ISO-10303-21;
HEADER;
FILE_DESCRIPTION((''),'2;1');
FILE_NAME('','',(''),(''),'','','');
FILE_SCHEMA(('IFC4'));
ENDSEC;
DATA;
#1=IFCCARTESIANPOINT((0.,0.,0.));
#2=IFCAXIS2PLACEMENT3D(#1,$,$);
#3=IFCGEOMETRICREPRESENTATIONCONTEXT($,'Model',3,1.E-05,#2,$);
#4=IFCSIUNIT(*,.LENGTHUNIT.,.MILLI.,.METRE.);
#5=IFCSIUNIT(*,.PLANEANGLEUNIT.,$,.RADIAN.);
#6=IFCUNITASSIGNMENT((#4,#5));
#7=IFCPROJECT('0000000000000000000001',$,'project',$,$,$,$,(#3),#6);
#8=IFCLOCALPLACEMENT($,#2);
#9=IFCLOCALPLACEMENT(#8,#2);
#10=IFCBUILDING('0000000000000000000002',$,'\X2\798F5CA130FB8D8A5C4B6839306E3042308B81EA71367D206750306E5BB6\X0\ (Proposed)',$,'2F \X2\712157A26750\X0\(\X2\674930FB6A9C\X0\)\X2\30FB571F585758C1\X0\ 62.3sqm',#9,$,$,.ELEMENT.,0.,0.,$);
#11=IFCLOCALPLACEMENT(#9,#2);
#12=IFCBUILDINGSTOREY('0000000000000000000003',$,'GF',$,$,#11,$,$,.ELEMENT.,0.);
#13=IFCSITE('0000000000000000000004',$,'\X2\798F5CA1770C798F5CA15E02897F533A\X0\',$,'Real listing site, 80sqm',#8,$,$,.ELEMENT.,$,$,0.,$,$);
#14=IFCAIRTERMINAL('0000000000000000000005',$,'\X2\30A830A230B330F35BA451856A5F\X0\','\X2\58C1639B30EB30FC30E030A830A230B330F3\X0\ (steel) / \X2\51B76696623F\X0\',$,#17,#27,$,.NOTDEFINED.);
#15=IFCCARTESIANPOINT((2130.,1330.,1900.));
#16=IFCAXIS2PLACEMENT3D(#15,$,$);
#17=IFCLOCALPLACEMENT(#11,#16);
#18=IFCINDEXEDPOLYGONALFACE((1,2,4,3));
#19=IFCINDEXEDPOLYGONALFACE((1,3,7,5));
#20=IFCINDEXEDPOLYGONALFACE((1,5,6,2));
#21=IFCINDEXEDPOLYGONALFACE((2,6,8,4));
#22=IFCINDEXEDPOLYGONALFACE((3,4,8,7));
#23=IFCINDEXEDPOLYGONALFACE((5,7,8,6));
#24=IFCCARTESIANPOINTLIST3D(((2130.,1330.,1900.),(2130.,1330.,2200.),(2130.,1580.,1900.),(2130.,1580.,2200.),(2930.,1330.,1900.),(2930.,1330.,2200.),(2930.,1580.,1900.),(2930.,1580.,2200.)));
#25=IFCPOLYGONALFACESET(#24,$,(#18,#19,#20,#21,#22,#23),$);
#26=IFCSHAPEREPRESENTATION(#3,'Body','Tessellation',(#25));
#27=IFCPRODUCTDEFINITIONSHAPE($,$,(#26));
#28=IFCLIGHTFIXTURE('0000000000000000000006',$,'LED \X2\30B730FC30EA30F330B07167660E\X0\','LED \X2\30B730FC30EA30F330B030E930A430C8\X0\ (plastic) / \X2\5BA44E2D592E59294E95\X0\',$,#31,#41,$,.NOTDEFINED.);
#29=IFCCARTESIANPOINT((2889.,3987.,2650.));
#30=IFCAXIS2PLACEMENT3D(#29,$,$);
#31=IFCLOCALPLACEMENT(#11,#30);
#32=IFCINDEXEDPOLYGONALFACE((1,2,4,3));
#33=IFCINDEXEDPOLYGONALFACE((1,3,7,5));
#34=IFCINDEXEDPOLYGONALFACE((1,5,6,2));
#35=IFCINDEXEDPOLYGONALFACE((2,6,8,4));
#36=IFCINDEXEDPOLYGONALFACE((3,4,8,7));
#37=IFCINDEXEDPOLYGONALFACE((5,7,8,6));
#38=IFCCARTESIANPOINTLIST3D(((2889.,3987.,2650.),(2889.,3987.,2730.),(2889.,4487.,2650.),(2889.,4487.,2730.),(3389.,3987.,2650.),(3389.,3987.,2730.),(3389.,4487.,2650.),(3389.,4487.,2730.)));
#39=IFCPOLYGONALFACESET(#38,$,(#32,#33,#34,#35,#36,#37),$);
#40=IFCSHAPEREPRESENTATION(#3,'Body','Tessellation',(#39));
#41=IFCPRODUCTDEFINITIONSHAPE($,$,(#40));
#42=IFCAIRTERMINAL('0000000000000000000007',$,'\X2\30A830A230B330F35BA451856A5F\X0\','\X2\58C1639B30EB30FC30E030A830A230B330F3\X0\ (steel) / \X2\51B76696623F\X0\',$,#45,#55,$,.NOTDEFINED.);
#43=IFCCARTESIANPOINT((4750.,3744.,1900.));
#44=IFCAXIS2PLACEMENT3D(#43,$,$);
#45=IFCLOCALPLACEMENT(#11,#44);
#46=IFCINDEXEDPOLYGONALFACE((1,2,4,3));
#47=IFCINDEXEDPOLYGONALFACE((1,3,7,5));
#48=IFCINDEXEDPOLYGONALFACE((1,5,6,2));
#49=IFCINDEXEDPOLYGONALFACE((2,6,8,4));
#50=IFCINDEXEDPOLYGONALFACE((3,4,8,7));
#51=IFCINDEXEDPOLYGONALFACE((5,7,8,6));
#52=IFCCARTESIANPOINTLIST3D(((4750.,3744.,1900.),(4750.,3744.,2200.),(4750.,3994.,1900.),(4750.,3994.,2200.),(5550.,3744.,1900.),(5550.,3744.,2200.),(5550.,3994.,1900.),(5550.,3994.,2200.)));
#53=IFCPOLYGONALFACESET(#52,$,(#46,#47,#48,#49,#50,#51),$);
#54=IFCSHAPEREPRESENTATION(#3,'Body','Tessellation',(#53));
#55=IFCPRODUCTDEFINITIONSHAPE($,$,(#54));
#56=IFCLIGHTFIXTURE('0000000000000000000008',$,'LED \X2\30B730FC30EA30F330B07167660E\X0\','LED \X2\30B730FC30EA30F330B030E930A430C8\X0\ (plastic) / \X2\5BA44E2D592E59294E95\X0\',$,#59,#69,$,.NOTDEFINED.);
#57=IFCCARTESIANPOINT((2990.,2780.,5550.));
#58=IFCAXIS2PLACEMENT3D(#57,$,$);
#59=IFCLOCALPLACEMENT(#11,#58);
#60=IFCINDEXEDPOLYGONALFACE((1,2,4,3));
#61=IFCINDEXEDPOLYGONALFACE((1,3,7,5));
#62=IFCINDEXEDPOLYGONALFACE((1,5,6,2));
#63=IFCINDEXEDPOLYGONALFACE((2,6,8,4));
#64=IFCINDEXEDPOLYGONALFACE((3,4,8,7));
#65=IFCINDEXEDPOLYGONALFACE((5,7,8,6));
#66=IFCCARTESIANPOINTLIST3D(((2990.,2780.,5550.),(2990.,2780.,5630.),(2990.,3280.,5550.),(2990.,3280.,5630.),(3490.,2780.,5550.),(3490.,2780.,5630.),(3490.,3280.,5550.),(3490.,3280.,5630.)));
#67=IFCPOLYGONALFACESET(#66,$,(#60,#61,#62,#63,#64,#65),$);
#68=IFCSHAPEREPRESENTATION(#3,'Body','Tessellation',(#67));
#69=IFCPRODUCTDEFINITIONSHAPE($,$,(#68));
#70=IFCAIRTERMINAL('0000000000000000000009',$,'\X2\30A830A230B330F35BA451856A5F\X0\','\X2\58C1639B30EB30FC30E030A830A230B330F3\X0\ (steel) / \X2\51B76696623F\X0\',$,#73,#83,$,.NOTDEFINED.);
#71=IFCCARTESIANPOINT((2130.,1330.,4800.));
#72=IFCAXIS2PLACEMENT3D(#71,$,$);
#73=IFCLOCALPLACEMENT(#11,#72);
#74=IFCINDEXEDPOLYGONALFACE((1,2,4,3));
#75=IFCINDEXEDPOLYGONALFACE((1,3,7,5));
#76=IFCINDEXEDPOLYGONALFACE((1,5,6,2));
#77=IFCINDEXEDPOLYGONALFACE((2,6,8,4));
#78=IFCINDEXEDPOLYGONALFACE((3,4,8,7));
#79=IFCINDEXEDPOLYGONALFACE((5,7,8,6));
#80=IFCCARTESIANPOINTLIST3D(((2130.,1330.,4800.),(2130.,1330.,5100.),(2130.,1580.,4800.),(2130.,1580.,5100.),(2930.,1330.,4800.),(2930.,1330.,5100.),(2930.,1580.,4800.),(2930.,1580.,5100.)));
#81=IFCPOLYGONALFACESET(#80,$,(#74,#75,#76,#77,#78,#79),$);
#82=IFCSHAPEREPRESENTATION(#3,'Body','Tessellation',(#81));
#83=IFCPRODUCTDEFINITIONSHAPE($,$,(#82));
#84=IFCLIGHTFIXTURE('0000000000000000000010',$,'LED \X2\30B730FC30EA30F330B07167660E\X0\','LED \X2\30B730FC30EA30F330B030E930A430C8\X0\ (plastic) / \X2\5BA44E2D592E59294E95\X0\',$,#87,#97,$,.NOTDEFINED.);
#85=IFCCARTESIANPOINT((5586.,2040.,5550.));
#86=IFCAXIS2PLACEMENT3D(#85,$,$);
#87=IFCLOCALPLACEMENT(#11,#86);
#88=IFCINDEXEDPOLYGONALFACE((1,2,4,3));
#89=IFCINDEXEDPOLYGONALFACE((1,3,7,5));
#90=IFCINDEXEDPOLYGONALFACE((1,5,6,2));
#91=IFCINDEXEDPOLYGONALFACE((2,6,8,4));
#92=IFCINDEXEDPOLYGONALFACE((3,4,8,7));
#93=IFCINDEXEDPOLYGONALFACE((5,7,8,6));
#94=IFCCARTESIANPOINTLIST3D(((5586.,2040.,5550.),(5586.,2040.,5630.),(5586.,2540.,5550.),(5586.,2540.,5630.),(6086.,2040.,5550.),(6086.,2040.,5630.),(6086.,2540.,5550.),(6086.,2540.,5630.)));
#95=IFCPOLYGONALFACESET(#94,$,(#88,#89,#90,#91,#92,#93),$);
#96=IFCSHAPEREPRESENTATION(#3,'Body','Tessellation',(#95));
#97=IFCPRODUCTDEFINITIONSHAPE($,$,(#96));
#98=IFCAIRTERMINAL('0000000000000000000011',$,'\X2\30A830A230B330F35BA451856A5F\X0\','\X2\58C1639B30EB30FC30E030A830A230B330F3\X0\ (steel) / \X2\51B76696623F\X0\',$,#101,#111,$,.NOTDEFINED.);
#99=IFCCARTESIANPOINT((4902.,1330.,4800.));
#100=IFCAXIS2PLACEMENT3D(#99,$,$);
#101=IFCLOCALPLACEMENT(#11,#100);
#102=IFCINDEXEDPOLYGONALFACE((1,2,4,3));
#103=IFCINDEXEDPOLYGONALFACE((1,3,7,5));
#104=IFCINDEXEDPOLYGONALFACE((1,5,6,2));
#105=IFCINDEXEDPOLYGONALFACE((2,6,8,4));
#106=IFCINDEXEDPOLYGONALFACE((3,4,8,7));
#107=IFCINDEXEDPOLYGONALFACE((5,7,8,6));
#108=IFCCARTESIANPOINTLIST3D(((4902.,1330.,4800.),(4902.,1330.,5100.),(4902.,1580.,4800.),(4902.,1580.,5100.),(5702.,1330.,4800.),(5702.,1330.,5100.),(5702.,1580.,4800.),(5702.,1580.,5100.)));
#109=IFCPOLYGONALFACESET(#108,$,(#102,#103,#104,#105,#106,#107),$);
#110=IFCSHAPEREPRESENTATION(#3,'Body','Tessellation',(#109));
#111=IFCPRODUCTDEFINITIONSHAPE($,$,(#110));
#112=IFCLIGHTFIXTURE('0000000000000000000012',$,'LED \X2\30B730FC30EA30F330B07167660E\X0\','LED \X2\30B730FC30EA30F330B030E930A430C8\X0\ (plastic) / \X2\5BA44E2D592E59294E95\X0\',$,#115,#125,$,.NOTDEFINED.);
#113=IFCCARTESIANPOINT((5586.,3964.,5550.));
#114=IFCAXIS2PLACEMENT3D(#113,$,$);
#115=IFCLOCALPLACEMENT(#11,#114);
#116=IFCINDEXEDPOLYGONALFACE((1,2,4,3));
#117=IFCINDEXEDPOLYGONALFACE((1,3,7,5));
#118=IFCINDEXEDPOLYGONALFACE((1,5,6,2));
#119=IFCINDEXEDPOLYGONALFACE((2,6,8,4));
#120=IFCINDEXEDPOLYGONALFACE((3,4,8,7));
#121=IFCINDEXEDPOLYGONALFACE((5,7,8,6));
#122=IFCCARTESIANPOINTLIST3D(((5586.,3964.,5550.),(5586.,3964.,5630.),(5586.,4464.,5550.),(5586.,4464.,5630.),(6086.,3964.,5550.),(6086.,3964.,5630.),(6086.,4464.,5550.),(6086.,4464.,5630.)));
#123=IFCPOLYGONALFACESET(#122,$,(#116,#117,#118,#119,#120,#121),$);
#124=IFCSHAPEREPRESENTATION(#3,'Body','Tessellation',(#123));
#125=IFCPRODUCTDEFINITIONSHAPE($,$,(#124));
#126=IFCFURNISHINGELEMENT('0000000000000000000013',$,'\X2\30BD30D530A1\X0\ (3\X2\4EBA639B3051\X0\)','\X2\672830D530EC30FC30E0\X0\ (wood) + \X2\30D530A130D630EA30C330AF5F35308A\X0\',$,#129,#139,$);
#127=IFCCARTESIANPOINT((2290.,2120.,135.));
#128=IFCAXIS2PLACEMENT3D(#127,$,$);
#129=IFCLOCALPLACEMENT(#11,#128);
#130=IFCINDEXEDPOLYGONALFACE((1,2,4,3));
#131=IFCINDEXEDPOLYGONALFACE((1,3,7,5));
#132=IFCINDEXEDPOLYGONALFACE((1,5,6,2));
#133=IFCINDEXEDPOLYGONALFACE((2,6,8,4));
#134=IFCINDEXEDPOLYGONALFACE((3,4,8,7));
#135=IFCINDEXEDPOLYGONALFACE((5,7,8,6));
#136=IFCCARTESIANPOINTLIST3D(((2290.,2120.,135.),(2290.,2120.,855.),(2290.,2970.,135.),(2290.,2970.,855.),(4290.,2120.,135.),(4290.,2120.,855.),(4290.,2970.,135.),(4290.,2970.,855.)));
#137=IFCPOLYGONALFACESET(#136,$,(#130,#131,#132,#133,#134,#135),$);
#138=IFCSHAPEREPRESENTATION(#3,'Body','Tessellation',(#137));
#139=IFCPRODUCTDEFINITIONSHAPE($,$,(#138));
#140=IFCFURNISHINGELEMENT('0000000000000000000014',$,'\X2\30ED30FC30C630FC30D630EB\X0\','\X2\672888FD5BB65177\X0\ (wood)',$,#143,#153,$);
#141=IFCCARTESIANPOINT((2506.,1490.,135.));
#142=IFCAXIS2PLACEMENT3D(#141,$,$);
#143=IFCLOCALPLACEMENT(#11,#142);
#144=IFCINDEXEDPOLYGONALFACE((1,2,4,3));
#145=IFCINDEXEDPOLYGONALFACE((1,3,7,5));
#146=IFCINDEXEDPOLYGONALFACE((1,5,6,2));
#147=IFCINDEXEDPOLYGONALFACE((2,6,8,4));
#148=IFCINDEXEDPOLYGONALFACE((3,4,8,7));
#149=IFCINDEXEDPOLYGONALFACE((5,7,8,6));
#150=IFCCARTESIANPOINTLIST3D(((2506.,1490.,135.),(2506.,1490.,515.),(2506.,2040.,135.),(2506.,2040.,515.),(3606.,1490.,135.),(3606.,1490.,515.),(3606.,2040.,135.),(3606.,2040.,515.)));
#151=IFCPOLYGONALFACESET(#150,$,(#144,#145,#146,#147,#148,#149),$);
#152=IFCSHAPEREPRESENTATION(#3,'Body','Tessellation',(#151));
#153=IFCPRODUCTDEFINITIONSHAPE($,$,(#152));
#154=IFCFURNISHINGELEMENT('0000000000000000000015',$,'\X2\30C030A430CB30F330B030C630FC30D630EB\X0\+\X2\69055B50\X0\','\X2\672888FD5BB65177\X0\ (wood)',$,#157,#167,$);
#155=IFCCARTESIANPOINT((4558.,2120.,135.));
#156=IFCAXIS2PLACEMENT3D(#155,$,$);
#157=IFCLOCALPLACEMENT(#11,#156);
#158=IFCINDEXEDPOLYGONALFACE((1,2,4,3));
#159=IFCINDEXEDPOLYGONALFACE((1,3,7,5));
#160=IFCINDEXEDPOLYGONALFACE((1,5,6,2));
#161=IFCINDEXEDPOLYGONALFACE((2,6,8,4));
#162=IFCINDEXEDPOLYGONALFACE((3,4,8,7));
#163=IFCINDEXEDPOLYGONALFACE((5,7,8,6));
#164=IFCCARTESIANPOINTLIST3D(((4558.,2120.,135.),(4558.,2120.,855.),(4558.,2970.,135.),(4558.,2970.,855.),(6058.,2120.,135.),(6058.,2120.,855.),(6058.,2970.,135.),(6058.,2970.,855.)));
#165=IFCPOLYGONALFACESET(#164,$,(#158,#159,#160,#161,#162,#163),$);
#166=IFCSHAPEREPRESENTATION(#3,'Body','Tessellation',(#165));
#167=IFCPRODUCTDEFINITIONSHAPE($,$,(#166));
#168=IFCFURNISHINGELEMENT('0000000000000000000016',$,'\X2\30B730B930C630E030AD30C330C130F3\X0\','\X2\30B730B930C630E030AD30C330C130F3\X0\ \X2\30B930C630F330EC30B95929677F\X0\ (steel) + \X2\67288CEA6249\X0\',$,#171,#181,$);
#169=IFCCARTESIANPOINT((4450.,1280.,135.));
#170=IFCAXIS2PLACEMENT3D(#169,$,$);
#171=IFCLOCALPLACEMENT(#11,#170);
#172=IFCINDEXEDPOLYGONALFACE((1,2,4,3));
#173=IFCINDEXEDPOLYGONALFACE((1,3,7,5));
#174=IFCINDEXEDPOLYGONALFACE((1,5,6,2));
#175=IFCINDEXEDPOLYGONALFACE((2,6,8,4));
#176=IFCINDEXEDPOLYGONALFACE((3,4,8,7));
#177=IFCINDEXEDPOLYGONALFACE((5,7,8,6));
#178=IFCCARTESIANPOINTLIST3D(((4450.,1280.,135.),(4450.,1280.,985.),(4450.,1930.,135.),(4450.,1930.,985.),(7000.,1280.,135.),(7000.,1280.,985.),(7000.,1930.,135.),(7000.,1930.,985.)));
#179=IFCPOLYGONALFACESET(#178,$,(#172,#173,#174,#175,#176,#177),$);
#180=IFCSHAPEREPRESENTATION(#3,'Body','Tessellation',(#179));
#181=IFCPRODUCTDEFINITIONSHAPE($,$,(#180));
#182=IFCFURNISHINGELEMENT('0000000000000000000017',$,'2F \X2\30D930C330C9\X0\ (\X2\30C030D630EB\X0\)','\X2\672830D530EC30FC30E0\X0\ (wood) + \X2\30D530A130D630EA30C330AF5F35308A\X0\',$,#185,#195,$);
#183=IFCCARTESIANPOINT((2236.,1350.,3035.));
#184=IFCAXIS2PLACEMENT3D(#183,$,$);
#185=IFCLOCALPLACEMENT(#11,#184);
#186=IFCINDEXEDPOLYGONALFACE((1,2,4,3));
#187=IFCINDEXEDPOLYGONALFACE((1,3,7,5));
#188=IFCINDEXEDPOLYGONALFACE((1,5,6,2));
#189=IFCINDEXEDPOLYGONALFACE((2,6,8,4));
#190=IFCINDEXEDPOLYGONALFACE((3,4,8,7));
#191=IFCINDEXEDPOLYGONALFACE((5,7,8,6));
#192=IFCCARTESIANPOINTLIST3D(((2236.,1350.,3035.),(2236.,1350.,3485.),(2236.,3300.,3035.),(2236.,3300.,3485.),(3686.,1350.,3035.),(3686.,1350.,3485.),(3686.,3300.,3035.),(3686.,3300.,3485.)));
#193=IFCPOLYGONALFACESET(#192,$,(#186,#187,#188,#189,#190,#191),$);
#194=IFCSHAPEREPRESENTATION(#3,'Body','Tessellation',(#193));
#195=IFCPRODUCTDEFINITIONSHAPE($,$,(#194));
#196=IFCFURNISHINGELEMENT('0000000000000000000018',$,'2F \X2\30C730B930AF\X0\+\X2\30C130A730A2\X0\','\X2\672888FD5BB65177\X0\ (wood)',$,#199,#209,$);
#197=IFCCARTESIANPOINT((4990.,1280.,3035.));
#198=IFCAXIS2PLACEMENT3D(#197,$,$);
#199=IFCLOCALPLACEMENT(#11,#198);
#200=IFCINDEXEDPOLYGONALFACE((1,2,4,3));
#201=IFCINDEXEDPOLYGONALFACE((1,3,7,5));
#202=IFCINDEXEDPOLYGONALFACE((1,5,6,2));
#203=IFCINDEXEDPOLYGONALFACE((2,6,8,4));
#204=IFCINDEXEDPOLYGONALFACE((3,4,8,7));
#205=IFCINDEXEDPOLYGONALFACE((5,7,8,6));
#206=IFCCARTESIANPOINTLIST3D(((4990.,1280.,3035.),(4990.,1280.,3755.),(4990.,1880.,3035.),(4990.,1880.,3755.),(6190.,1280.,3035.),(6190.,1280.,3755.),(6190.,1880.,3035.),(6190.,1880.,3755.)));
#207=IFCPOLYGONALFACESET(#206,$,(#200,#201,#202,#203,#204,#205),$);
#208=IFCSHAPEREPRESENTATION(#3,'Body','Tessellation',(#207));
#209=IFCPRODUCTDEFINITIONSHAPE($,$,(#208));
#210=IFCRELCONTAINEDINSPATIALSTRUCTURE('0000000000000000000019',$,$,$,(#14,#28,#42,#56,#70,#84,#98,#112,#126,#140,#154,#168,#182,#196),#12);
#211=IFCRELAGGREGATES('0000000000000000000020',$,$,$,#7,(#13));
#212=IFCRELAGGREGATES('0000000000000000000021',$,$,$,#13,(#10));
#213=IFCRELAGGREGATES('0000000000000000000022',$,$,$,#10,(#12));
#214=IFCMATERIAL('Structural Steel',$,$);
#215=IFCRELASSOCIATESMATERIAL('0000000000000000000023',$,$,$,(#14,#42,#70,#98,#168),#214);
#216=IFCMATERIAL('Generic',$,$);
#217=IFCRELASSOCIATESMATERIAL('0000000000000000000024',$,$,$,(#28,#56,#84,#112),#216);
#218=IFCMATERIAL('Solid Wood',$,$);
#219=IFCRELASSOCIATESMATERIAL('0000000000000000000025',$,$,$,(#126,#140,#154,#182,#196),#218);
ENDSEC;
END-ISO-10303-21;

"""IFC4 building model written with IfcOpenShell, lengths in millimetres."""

from ifc_helpers import new_model, si_unit, frame, frame_2d, origin, place, context, project, spatial, rectangle, extrude, material, element, save


model = new_model("IFC4")

# Units and contexts
model_context = context("Model", 3, precision=1e-05, world=origin())
ifc_project = project(units=[si_unit("LENGTHUNIT", "METRE", prefix="MILLI"), si_unit("PLANEANGLEUNIT", "RADIAN")], contexts=[model_context])

# Site, building, storey
site_placement = place(None, origin())
site = spatial("IfcSite", under=ifc_project, at=site_placement, Name="福岡県福岡市西区", ObjectType="Real listing site, 80sqm", CompositionType="ELEMENT", RefElevation=0.0)
building_placement = place(site_placement, origin())
building = spatial("IfcBuilding", under=site, at=building_placement, Name="福岡・越屋根のある自然素材の家 (Proposed)", ObjectType="2F 無垢材(杉・檜)・土塗壁 62.3sqm", CompositionType="ELEMENT", ElevationOfRefHeight=0.0, ElevationOfTerrain=0.0)
storey_placement = place(building_placement, origin())
storey = spatial("IfcBuildingStorey", under=building, at=storey_placement, Name="GF", CompositionType="ELEMENT", Elevation=0.0)

# Shared definitions
ifc_material_1 = material(Name="Solid Wood")

# Shared definitions
ifc_material_2 = material(Name="Structural Steel")

# Shared definitions
ifc_material_3 = material(Name="Generic")

# Air terminal
air_terminal_1_placement = place(storey_placement, frame((2130.0, 1330.0, 1900.0)))
element("IfcAirTerminal", 1, at=air_terminal_1_placement, inside=storey, material=ifc_material_2, Name="エアコン室内機", Description="壁掛ルームエアコン (steel) / 冷暖房", PredefinedType="NOTDEFINED", context=model_context, shape_type="SweptSolid", body=[
    extrude(rectangle(XDim=800.0, YDim=250.0, at=frame_2d((400.0, 125.0))), frame((2130.0, 1330.0, 1900.0)), (0.0, 0.0, 1.0), 300.0),
])

# Light fixture
light_fixture_1_placement = place(storey_placement, frame((2889.0, 3987.0, 2650.0)))
element("IfcLightFixture", 2, at=light_fixture_1_placement, inside=storey, material=ifc_material_3, Name="LED シーリング照明", Description="LED シーリングライト (plastic) / 室中央天井", PredefinedType="NOTDEFINED", context=model_context, shape_type="SweptSolid", body=[
    extrude(rectangle(XDim=500.0, YDim=500.0, at=frame_2d((250.0, 250.0))), frame((2889.0, 3987.0, 2650.0)), (0.0, 0.0, 1.0), 80.0),
])

# Air terminal
air_terminal_2_placement = place(storey_placement, frame((4750.0, 3744.0, 1900.0)))
element("IfcAirTerminal", 3, at=air_terminal_2_placement, inside=storey, material=ifc_material_2, Name="エアコン室内機", Description="壁掛ルームエアコン (steel) / 冷暖房", PredefinedType="NOTDEFINED", context=model_context, shape_type="SweptSolid", body=[
    extrude(rectangle(XDim=800.0, YDim=250.0, at=frame_2d((400.0, 125.0))), frame((4750.0, 3744.0, 1900.0)), (0.0, 0.0, 1.0), 300.0),
])

# Light fixture
light_fixture_2_placement = place(storey_placement, frame((2990.0, 2780.0, 5550.0)))
element("IfcLightFixture", 4, at=light_fixture_2_placement, inside=storey, material=ifc_material_3, Name="LED シーリング照明", Description="LED シーリングライト (plastic) / 室中央天井", PredefinedType="NOTDEFINED", context=model_context, shape_type="SweptSolid", body=[
    extrude(rectangle(XDim=500.0, YDim=500.0, at=frame_2d((250.0, 250.0))), frame((2990.0, 2780.0, 5550.0)), (0.0, 0.0, 1.0), 80.0),
])

# Air terminal
air_terminal_3_placement = place(storey_placement, frame((2130.0, 1330.0, 4800.0)))
element("IfcAirTerminal", 5, at=air_terminal_3_placement, inside=storey, material=ifc_material_2, Name="エアコン室内機", Description="壁掛ルームエアコン (steel) / 冷暖房", PredefinedType="NOTDEFINED", context=model_context, shape_type="SweptSolid", body=[
    extrude(rectangle(XDim=800.0, YDim=250.0, at=frame_2d((400.0, 125.0))), frame((2130.0, 1330.0, 4800.0)), (0.0, 0.0, 1.0), 300.0),
])

# Light fixture
light_fixture_3_placement = place(storey_placement, frame((5586.0, 2040.0, 5550.0)))
element("IfcLightFixture", 6, at=light_fixture_3_placement, inside=storey, material=ifc_material_3, Name="LED シーリング照明", Description="LED シーリングライト (plastic) / 室中央天井", PredefinedType="NOTDEFINED", context=model_context, shape_type="SweptSolid", body=[
    extrude(rectangle(XDim=500.0, YDim=500.0, at=frame_2d((250.0, 250.0))), frame((5586.0, 2040.0, 5550.0)), (0.0, 0.0, 1.0), 80.0),
])

# Air terminal
air_terminal_4_placement = place(storey_placement, frame((4902.0, 1330.0, 4800.0)))
element("IfcAirTerminal", 7, at=air_terminal_4_placement, inside=storey, material=ifc_material_2, Name="エアコン室内機", Description="壁掛ルームエアコン (steel) / 冷暖房", PredefinedType="NOTDEFINED", context=model_context, shape_type="SweptSolid", body=[
    extrude(rectangle(XDim=800.0, YDim=250.0, at=frame_2d((400.0, 125.0))), frame((4902.0, 1330.0, 4800.0)), (0.0, 0.0, 1.0), 300.0),
])

# Light fixture
light_fixture_4_placement = place(storey_placement, frame((5586.0, 3964.0, 5550.0)))
element("IfcLightFixture", 8, at=light_fixture_4_placement, inside=storey, material=ifc_material_3, Name="LED シーリング照明", Description="LED シーリングライト (plastic) / 室中央天井", PredefinedType="NOTDEFINED", context=model_context, shape_type="SweptSolid", body=[
    extrude(rectangle(XDim=500.0, YDim=500.0, at=frame_2d((250.0, 250.0))), frame((5586.0, 3964.0, 5550.0)), (0.0, 0.0, 1.0), 80.0),
])

# Furnishing elements
furnishing_1_placement = place(storey_placement, frame((2290.0, 2120.0, 135.0)))
element("IfcFurnishingElement", 9, at=furnishing_1_placement, inside=storey, material=ifc_material_1, Name="ソファ (3人掛け)", Description="木フレーム (wood) + ファブリック張り", context=model_context, shape_type="SweptSolid", body=[
    extrude(rectangle(XDim=2000.0, YDim=850.0, at=frame_2d((1000.0, 425.0))), frame((2290.0, 2120.0, 135.0)), (0.0, 0.0, 1.0), 720.0),
])
furnishing_2_placement = place(storey_placement, frame((2506.0, 1490.0, 135.0)))
element("IfcFurnishingElement", 10, at=furnishing_2_placement, inside=storey, material=ifc_material_1, Name="ローテーブル", Description="木製家具 (wood)", context=model_context, shape_type="SweptSolid", body=[
    extrude(rectangle(XDim=1100.0, YDim=550.0, at=frame_2d((550.0, 275.0))), frame((2506.0, 1490.0, 135.0)), (0.0, 0.0, 1.0), 380.0),
])
furnishing_3_placement = place(storey_placement, frame((4558.0, 2120.0, 135.0)))
element("IfcFurnishingElement", 11, at=furnishing_3_placement, inside=storey, material=ifc_material_1, Name="ダイニングテーブル+椅子", Description="木製家具 (wood)", context=model_context, shape_type="SweptSolid", body=[
    extrude(rectangle(XDim=1500.0, YDim=850.0, at=frame_2d((750.0, 425.0))), frame((4558.0, 2120.0, 135.0)), (0.0, 0.0, 1.0), 720.0),
])
furnishing_4_placement = place(storey_placement, frame((4450.0, 1280.0, 135.0)))
element("IfcFurnishingElement", 12, at=furnishing_4_placement, inside=storey, material=ifc_material_2, Name="システムキッチン", Description="システムキッチン ステンレス天板 (steel) + 木質扉", context=model_context, shape_type="SweptSolid", body=[
    extrude(rectangle(XDim=2550.0, YDim=650.0, at=frame_2d((1275.0, 325.0))), frame((4450.0, 1280.0, 135.0)), (0.0, 0.0, 1.0), 850.0),
])
furnishing_5_placement = place(storey_placement, frame((2236.0, 1350.0, 3035.0)))
element("IfcFurnishingElement", 13, at=furnishing_5_placement, inside=storey, material=ifc_material_1, Name="2F ベッド (ダブル)", Description="木フレーム (wood) + ファブリック張り", context=model_context, shape_type="SweptSolid", body=[
    extrude(rectangle(XDim=1450.0, YDim=1950.0, at=frame_2d((725.0, 975.0))), frame((2236.0, 1350.0, 3035.0)), (0.0, 0.0, 1.0), 450.0),
])
furnishing_6_placement = place(storey_placement, frame((4990.0, 1280.0, 3035.0)))
element("IfcFurnishingElement", 14, at=furnishing_6_placement, inside=storey, material=ifc_material_1, Name="2F デスク+チェア", Description="木製家具 (wood)", context=model_context, shape_type="SweptSolid", body=[
    extrude(rectangle(XDim=1200.0, YDim=600.0, at=frame_2d((600.0, 300.0))), frame((4990.0, 1280.0, 3035.0)), (0.0, 0.0, 1.0), 720.0),
])

save(model, "model.ifc")
